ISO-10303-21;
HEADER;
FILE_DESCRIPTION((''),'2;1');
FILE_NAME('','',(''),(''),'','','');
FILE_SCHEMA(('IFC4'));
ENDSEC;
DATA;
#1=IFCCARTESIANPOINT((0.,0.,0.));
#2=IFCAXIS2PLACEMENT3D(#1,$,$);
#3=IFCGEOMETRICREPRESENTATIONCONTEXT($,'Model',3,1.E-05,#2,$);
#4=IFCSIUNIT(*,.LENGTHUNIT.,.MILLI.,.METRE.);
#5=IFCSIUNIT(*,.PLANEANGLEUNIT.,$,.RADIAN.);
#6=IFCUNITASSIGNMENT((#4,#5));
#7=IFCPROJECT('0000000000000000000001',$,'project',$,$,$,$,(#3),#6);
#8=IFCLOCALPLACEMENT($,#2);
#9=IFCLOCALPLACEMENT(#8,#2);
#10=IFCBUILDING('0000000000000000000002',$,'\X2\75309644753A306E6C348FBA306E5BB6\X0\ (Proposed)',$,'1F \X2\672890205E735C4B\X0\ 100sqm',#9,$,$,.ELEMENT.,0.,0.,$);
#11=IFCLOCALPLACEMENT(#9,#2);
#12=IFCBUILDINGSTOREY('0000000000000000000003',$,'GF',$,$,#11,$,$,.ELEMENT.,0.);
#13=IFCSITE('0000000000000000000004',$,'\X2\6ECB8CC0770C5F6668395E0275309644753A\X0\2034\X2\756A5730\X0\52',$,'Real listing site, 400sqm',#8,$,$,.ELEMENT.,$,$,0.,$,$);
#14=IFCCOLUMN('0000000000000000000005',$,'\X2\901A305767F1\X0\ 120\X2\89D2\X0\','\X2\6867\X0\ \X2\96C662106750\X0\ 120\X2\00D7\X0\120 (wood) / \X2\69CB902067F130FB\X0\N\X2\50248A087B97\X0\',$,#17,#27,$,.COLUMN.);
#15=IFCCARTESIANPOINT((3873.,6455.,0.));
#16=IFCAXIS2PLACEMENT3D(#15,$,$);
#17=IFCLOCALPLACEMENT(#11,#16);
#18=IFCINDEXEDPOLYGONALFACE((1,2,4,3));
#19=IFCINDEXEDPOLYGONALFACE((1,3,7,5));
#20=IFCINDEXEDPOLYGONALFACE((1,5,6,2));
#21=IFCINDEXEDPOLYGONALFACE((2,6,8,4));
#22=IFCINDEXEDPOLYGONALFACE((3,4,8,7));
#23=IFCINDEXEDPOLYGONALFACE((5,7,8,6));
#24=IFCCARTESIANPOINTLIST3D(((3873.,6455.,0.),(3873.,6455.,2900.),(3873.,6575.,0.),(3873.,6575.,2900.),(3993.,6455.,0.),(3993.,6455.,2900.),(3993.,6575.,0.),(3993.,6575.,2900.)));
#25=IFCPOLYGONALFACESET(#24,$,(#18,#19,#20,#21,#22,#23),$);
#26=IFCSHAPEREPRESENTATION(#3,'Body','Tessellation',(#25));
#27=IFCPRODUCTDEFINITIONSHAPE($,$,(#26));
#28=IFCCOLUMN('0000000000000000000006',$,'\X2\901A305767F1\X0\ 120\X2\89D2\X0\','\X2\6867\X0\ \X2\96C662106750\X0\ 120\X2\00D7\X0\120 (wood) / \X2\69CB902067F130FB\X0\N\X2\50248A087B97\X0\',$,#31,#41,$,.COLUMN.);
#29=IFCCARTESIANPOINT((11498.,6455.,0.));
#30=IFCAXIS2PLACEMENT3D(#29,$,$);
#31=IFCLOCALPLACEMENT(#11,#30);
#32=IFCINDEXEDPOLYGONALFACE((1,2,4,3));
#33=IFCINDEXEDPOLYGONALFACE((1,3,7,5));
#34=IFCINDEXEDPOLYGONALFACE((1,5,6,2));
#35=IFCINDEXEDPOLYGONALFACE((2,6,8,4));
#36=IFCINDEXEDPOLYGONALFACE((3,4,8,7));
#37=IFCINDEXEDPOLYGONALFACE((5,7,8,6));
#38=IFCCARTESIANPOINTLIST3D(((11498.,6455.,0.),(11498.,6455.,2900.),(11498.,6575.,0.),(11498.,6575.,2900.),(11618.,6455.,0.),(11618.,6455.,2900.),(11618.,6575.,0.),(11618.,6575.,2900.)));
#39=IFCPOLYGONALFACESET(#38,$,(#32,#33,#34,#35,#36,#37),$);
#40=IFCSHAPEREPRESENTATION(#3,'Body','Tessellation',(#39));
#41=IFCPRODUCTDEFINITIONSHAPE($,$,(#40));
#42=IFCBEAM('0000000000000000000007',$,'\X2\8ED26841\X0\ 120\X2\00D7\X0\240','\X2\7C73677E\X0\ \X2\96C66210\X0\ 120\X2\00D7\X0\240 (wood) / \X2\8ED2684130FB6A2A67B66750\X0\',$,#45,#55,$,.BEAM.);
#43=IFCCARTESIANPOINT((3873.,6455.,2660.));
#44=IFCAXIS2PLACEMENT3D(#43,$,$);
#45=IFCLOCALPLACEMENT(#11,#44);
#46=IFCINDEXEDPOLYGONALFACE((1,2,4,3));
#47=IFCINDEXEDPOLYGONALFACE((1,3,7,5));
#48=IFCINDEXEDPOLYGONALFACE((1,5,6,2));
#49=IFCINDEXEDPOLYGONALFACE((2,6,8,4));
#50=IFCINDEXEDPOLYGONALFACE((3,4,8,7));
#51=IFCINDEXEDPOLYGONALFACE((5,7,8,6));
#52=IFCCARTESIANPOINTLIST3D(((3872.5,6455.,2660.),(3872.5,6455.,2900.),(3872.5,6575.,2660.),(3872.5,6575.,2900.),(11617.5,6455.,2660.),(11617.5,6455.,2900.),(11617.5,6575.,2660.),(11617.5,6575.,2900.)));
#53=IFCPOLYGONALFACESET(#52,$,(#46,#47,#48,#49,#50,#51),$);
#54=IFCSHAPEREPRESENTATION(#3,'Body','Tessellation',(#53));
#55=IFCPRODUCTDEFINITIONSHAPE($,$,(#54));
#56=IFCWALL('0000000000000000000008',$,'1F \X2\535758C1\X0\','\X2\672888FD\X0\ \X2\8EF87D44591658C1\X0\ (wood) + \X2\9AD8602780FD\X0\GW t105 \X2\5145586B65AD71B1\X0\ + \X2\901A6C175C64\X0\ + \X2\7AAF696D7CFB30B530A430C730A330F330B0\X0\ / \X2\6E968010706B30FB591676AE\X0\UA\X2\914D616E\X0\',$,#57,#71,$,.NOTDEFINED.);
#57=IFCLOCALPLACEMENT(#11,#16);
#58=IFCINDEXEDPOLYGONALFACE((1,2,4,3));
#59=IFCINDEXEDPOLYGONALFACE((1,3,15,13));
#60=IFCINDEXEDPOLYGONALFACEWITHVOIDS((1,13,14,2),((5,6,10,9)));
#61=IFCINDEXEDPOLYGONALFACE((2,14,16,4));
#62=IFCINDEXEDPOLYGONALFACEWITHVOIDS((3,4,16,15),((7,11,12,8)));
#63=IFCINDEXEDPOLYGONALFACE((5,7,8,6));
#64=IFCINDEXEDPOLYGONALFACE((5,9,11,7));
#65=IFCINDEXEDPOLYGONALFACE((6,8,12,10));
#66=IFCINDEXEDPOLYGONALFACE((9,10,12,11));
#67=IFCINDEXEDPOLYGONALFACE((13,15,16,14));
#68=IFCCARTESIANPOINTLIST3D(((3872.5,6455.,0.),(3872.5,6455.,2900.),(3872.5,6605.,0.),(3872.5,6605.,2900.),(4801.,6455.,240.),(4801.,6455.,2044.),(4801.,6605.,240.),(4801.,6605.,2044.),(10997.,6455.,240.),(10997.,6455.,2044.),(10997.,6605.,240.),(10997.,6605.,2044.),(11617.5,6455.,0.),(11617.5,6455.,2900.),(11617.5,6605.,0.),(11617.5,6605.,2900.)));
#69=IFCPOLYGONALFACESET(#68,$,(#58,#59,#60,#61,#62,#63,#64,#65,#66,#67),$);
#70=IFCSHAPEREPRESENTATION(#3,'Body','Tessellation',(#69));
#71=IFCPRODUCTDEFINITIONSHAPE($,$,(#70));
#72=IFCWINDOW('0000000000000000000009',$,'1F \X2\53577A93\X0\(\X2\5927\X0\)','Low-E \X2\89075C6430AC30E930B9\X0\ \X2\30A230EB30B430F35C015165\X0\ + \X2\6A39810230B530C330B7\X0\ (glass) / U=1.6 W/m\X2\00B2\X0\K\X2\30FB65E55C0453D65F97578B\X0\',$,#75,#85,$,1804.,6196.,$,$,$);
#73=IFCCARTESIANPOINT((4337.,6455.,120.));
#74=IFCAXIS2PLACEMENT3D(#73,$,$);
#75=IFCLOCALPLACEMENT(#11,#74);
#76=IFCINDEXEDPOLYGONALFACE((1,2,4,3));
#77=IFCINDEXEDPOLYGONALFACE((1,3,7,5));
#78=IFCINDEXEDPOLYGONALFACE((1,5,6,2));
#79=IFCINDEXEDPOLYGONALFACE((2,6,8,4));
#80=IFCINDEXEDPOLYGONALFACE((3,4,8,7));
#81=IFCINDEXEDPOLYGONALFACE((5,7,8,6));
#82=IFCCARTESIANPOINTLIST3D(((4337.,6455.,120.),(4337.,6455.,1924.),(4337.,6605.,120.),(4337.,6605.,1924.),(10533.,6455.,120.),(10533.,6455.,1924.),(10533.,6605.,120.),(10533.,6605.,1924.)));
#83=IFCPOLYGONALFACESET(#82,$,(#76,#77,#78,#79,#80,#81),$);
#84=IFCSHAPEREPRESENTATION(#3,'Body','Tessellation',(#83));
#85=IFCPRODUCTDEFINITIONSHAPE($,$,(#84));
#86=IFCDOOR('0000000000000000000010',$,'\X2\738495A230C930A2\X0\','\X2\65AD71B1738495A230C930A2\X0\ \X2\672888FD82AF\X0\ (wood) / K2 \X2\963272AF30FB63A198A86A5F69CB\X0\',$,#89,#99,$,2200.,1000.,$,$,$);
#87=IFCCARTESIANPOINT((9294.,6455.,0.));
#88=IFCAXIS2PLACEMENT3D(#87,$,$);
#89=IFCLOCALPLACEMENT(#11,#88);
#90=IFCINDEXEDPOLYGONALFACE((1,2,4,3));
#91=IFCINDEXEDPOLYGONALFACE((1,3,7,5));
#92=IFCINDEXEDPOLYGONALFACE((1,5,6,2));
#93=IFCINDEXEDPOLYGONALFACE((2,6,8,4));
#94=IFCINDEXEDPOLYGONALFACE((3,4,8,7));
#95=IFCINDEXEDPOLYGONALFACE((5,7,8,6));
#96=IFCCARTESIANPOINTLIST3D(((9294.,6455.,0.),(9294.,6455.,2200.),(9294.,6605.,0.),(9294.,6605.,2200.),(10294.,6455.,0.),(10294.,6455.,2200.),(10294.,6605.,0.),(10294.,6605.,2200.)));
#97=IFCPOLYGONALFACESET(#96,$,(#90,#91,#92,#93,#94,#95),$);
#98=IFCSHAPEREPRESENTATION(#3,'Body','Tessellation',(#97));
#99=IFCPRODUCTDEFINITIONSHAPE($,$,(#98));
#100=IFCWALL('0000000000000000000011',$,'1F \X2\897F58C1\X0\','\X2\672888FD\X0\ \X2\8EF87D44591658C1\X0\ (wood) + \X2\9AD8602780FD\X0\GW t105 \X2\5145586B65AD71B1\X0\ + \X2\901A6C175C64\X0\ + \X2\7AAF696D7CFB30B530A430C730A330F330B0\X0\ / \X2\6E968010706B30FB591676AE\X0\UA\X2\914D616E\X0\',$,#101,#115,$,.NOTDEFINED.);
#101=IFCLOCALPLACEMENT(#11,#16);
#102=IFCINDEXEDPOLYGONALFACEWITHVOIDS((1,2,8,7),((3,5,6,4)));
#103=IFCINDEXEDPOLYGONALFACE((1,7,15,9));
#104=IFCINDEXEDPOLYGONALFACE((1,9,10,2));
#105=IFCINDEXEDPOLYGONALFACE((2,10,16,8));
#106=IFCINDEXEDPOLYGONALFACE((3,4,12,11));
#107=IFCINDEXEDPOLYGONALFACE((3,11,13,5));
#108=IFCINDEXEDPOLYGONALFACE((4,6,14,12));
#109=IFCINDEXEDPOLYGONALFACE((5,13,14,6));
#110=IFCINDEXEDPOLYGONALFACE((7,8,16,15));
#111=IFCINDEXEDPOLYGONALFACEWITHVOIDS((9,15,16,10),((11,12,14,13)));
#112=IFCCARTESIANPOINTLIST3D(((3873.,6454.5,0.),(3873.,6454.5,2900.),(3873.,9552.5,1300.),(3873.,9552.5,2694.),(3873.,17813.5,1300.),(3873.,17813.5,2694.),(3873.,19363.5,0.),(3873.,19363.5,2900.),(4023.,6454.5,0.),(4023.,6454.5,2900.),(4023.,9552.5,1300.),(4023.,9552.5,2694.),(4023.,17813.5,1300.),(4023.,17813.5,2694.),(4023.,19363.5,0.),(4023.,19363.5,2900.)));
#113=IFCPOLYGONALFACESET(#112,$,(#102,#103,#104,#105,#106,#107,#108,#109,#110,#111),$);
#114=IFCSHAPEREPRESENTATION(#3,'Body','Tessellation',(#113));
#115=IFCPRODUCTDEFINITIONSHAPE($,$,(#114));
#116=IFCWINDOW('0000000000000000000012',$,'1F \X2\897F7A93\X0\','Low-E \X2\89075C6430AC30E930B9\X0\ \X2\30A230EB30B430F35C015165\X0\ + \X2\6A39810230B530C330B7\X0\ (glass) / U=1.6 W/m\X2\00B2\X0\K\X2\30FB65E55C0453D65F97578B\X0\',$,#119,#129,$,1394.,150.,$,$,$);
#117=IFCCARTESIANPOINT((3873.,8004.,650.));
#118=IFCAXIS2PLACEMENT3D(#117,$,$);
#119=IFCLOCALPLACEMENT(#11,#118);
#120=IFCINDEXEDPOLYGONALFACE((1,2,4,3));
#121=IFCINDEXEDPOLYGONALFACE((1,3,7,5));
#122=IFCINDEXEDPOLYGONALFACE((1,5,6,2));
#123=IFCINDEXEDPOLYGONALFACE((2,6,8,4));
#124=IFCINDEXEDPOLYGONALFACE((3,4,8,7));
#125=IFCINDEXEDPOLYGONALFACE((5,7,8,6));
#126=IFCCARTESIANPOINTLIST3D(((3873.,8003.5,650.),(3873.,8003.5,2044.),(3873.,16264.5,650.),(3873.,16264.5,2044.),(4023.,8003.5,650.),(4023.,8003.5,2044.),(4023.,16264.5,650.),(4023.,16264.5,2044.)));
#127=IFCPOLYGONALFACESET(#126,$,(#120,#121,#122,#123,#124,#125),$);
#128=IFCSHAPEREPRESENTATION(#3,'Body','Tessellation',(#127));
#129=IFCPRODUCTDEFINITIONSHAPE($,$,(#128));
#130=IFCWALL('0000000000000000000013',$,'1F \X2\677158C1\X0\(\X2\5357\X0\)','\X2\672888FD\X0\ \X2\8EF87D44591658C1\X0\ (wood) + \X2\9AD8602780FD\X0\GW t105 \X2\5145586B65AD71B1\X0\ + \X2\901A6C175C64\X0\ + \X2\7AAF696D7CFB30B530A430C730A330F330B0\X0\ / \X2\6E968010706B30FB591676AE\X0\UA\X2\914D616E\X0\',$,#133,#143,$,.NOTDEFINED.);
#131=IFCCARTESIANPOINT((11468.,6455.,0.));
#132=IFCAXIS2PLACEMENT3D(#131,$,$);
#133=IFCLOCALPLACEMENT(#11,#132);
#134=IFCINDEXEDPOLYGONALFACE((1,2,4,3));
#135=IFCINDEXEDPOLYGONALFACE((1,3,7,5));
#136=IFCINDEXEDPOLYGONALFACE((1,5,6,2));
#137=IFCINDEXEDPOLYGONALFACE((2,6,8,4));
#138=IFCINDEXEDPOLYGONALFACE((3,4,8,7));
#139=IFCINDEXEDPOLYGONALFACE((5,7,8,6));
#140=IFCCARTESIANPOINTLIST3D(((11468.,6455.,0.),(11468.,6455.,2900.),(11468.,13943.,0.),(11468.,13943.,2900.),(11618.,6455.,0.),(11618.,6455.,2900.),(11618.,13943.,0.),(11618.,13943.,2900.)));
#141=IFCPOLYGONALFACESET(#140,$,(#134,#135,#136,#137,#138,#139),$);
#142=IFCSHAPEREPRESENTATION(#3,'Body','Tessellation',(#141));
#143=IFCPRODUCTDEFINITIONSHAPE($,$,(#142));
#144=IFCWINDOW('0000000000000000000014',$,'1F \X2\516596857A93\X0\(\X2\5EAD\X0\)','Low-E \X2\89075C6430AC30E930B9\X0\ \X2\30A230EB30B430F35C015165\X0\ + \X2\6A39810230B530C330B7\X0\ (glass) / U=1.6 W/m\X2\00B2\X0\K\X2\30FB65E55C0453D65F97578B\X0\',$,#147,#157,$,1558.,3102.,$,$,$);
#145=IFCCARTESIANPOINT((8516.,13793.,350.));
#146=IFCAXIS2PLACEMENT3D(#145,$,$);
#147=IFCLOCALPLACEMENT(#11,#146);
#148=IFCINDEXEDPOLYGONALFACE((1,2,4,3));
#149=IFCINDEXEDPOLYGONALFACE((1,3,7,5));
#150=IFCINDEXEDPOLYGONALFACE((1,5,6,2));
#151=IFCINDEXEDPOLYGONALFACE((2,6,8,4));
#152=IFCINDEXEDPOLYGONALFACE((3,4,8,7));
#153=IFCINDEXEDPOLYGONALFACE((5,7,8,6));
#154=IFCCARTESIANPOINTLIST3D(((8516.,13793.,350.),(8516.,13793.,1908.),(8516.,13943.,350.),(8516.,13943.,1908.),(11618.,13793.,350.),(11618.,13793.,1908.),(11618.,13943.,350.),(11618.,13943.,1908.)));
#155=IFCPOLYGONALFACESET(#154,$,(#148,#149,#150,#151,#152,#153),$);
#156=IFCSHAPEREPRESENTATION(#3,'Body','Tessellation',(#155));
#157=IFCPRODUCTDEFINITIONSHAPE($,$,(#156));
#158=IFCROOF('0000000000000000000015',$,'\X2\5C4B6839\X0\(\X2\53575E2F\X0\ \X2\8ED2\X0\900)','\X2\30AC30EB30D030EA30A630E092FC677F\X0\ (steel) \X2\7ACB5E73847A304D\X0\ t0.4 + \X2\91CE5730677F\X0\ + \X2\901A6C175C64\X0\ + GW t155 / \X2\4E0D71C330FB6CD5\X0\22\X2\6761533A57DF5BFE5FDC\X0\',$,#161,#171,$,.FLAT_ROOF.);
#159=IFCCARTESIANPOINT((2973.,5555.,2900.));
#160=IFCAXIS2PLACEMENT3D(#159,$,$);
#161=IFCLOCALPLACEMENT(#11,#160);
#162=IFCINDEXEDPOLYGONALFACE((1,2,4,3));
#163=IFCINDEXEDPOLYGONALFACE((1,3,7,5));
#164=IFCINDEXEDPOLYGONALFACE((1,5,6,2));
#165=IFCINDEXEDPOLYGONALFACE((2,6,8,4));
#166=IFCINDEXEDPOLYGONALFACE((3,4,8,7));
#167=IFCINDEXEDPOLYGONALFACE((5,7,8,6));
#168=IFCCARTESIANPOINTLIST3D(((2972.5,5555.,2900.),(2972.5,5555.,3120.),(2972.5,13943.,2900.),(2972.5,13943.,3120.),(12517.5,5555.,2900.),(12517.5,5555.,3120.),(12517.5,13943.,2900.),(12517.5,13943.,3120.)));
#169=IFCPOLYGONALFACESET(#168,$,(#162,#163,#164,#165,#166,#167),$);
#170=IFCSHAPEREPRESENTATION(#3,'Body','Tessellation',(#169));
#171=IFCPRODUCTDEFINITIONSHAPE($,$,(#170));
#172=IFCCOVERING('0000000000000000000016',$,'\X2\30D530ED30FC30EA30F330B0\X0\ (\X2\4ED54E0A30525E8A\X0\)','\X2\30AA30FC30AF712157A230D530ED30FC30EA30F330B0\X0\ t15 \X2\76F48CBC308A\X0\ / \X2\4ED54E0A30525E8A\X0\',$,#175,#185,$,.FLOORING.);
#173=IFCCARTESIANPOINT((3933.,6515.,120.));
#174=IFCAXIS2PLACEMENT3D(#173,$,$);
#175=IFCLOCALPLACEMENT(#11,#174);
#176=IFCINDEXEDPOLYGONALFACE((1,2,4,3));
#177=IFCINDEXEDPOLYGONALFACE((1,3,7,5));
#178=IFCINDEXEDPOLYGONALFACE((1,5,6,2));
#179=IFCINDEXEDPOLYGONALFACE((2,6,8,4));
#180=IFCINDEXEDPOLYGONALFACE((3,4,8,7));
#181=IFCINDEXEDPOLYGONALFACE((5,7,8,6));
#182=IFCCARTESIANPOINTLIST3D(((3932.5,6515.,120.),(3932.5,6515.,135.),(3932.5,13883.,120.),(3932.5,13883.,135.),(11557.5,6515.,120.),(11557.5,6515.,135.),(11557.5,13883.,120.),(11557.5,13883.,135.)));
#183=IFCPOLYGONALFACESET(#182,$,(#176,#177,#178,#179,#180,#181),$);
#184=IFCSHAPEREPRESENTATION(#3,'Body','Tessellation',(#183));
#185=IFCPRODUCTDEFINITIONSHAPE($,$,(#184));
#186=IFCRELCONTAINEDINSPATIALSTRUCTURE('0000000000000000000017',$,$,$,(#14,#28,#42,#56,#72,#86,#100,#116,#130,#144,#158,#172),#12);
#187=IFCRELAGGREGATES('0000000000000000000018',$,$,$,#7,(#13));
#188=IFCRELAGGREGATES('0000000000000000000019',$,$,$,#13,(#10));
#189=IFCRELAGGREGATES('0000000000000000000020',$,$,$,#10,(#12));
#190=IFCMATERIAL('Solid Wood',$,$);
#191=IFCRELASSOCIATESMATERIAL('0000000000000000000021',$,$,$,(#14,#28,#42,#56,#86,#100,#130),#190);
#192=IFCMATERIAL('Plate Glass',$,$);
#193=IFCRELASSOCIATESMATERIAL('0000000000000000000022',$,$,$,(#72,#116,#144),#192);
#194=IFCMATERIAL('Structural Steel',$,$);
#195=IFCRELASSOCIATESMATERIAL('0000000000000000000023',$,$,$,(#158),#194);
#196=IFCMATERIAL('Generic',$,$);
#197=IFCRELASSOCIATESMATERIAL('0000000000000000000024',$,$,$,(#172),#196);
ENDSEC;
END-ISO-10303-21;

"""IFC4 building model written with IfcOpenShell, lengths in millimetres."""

from ifc_helpers import new_model, si_unit, frame, frame_2d, origin, place, context, project, spatial, rectangle, extrude, material, element, fill, save


model = new_model("IFC4")

# Units and contexts
model_context = context("Model", 3, precision=1e-05, world=origin())
ifc_project = project(units=[si_unit("LENGTHUNIT", "METRE", prefix="MILLI"), si_unit("PLANEANGLEUNIT", "RADIAN")], contexts=[model_context])

# Site, building, storey
site_placement = place(None, origin())
site = spatial("IfcSite", under=ifc_project, at=site_placement, Name="滋賀県彦根市田附町2034番地52", ObjectType="Real listing site, 400sqm", CompositionType="ELEMENT", RefElevation=0.0)
building_placement = place(site_placement, origin())
building = spatial("IfcBuilding", under=site, at=building_placement, Name="田附町の水辺の家 (Proposed)", ObjectType="1F 木造平屋 100sqm", CompositionType="ELEMENT", ElevationOfRefHeight=0.0, ElevationOfTerrain=0.0)
storey_placement = place(building_placement, origin())
storey = spatial("IfcBuildingStorey", under=building, at=storey_placement, Name="GF", CompositionType="ELEMENT", Elevation=0.0)

# Columns
ifc_material_1 = material(Name="Solid Wood")
column_1_placement = place(storey_placement, frame((3873.0, 6455.0, 0.0)))
element("IfcColumn", 1, at=column_1_placement, inside=storey, material=ifc_material_1, Name="通し柱 120角", Description="桧 集成材 120×120 (wood) / 構造柱・N値計算", PredefinedType="COLUMN", context=model_context, shape_type="SweptSolid", body=[
    extrude(rectangle(XDim=120.0, YDim=120.0, at=frame_2d((60.0, 60.0))), frame((3873.0, 6455.0, 0.0)), (0.0, 0.0, 1.0), 2900.0),
])
column_2_placement = place(storey_placement, frame((11498.0, 6455.0, 0.0)))
element("IfcColumn", 2, at=column_2_placement, inside=storey, material=ifc_material_1, Name="通し柱 120角", Description="桧 集成材 120×120 (wood) / 構造柱・N値計算", PredefinedType="COLUMN", context=model_context, shape_type="SweptSolid", body=[
    extrude(rectangle(XDim=120.0, YDim=120.0, at=frame_2d((60.0, 60.0))), frame((11498.0, 6455.0, 0.0)), (0.0, 0.0, 1.0), 2900.0),
])

# Beam
beam_1_placement = place(storey_placement, frame((3873.0, 6455.0, 2660.0)))
element("IfcBeam", 3, at=beam_1_placement, inside=storey, material=ifc_material_1, Name="軒桁 120×240", Description="米松 集成 120×240 (wood) / 軒桁・横架材", PredefinedType="BEAM", context=model_context, shape_type="SweptSolid", body=[
    extrude(rectangle(XDim=7745.0, YDim=120.0, at=frame_2d((3872.0, 60.0))), frame((3873.0, 6455.0, 2660.0)), (0.0, 0.0, 1.0), 240.0),
])

# Wall, openings, window, door
wall_1_placement = place(storey_placement, frame((3873.0, 6455.0, 0.0)))
wall_1 = element("IfcWall", 4, at=wall_1_placement, inside=storey, material=ifc_material_1, Name="1F 南壁", Description="木製 軸組外壁 (wood) + 高性能GW t105 充填断熱 + 通気層 + 窯業系サイディング / 準耐火・外皮UA配慮", PredefinedType="NOTDEFINED", context=model_context, shape_type="SweptSolid", body=[
    extrude(rectangle(XDim=7745.0, YDim=150.0, at=frame_2d((3872.0, 75.0))), frame((3873.0, 6455.0, 0.0)), (0.0, 0.0, 1.0), 2900.0),
])
opening_1_placement = place(storey_placement, frame((4337.0, 6455.0, 120.0)))
opening_1 = element("IfcOpeningElement", 5, at=opening_1_placement, cuts=wall_1, PredefinedType="NOTDEFINED", context=model_context, shape_type="SweptSolid", body=[
    extrude(rectangle(XDim=6196.0, YDim=150.0, at=frame_2d((3098.0, 75.0))), frame((4337.0, 6455.0, 120.0)), (0.0, 0.0, 1.0), 1804.0),
])
opening_2_placement = place(storey_placement, frame((9294.0, 6455.0, 0.0)))
opening_2 = element("IfcOpeningElement", 6, at=opening_2_placement, cuts=wall_1, PredefinedType="NOTDEFINED", context=model_context, shape_type="SweptSolid", body=[
    extrude(rectangle(XDim=1000.0, YDim=150.0, at=frame_2d((500.0, 75.0))), frame((9294.0, 6455.0, 0.0)), (0.0, 0.0, 1.0), 2200.0),
])
ifc_material_2 = material(Name="Plate Glass")
window_1_placement = place(storey_placement, frame((4337.0, 6455.0, 120.0)))
window_1 = element("IfcWindow", 7, at=window_1_placement, inside=storey, material=ifc_material_2, Name="1F 南窓(大)", Description="Low-E 複層ガラス アルゴン封入 + 樹脂サッシ (glass) / U=1.6 W/m²K・日射取得型", OverallHeight=1804.0, OverallWidth=6196.0, context=model_context, shape_type="SweptSolid", body=[
    extrude(rectangle(XDim=6196.0, YDim=150.0, at=frame_2d((3098.0, 75.0))), frame((4337.0, 6455.0, 120.0)), (0.0, 0.0, 1.0), 1804.0),
])
fill(opening_1, window_1)
door_1_placement = place(storey_placement, frame((9294.0, 6455.0, 0.0)))
door_1 = element("IfcDoor", 8, at=door_1_placement, inside=storey, material=ifc_material_1, Name="玄関ドア", Description="断熱玄関ドア 木製芯 (wood) / K2 防犯・採風機構", OverallHeight=2200.0, OverallWidth=1000.0, context=model_context, shape_type="SweptSolid", body=[
    extrude(rectangle(XDim=1000.0, YDim=150.0, at=frame_2d((500.0, 75.0))), frame((9294.0, 6455.0, 0.0)), (0.0, 0.0, 1.0), 2200.0),
])
fill(opening_2, door_1)

# Walls, openings, windows
wall_2_placement = place(storey_placement, frame((3873.0, 6455.0, 0.0)))
wall_2 = element("IfcWall", 9, at=wall_2_placement, inside=storey, material=ifc_material_1, Name="1F 西壁", Description="木製 軸組外壁 (wood) + 高性能GW t105 充填断熱 + 通気層 + 窯業系サイディング / 準耐火・外皮UA配慮", PredefinedType="NOTDEFINED", context=model_context, shape_type="SweptSolid", body=[
    extrude(rectangle(XDim=150.0, YDim=12909.0, at=frame_2d((75.0, 6454.0))), frame((3873.0, 6455.0, 0.0)), (0.0, 0.0, 1.0), 2900.0),
])
opening_3_placement = place(storey_placement, frame((3873.0, 8004.0, 650.0)))
opening_3 = element("IfcOpeningElement", 10, at=opening_3_placement, cuts=wall_2, PredefinedType="NOTDEFINED", context=model_context, shape_type="SweptSolid", body=[
    extrude(rectangle(XDim=150.0, YDim=8261.0, at=frame_2d((75.0, 4130.0))), frame((3873.0, 8004.0, 650.0)), (0.0, 0.0, 1.0), 1394.0),
])
window_2_placement = place(storey_placement, frame((3873.0, 8004.0, 650.0)))
window_2 = element("IfcWindow", 11, at=window_2_placement, inside=storey, material=ifc_material_2, Name="1F 西窓", Description="Low-E 複層ガラス アルゴン封入 + 樹脂サッシ (glass) / U=1.6 W/m²K・日射取得型", OverallHeight=1394.0, OverallWidth=150.0, context=model_context, shape_type="SweptSolid", body=[
    extrude(rectangle(XDim=150.0, YDim=8261.0, at=frame_2d((75.0, 4130.0))), frame((3873.0, 8004.0, 650.0)), (0.0, 0.0, 1.0), 1394.0),
])
fill(opening_3, window_2)
wall_3_placement = place(storey_placement, frame((11468.0, 6455.0, 0.0)))
wall_3 = element("IfcWall", 12, at=wall_3_placement, inside=storey, material=ifc_material_1, Name="1F 東壁(南)", Description="木製 軸組外壁 (wood) + 高性能GW t105 充填断熱 + 通気層 + 窯業系サイディング / 準耐火・外皮UA配慮", PredefinedType="NOTDEFINED", context=model_context, shape_type="SweptSolid", body=[
    extrude(rectangle(XDim=150.0, YDim=7488.0, at=frame_2d((75.0, 3744.0))), frame((11468.0, 6455.0, 0.0)), (0.0, 0.0, 1.0), 2900.0),
])
opening_4_placement = place(storey_placement, frame((8516.0, 13793.0, 350.0)))
opening_4 = element("IfcOpeningElement", 13, at=opening_4_placement, cuts=wall_3, PredefinedType="NOTDEFINED", context=model_context, shape_type="SweptSolid", body=[
    extrude(rectangle(XDim=3102.0, YDim=150.0, at=frame_2d((1551.0, 75.0))), frame((8516.0, 13793.0, 350.0)), (0.0, 0.0, 1.0), 1558.0),
])
window_3_placement = place(storey_placement, frame((8516.0, 13793.0, 350.0)))
window_3 = element("IfcWindow", 14, at=window_3_placement, inside=storey, material=ifc_material_2, Name="1F 入隅窓(庭)", Description="Low-E 複層ガラス アルゴン封入 + 樹脂サッシ (glass) / U=1.6 W/m²K・日射取得型", OverallHeight=1558.0, OverallWidth=3102.0, context=model_context, shape_type="SweptSolid", body=[
    extrude(rectangle(XDim=3102.0, YDim=150.0, at=frame_2d((1551.0, 75.0))), frame((8516.0, 13793.0, 350.0)), (0.0, 0.0, 1.0), 1558.0),
])
fill(opening_4, window_3)

# Roof
ifc_material_3 = material(Name="Structural Steel")
roof_placement = place(storey_placement, frame((2973.0, 5555.0, 2900.0)))
element("IfcRoof", 15, at=roof_placement, inside=storey, material=ifc_material_3, Name="屋根(南帯 軒900)", Description="ガルバリウム鋼板 (steel) 立平葺き t0.4 + 野地板 + 通気層 + GW t155 / 不燃・法22条区域対応", PredefinedType="FLAT_ROOF", context=model_context, shape_type="SweptSolid", body=[
    extrude(rectangle(XDim=9545.0, YDim=8388.0, at=frame_2d((4772.0, 4194.0))), frame((2973.0, 5555.0, 2900.0)), (0.0, 0.0, 1.0), 220.0),
])

# Covering
ifc_material_4 = material(Name="Generic")
covering_1_placement = place(storey_placement, frame((3933.0, 6515.0, 120.0)))
element("IfcCovering", 16, at=covering_1_placement, inside=storey, material=ifc_material_4, Name="フローリング (仕上げ床)", Description="オーク無垢フローリング t15 直貼り / 仕上げ床", PredefinedType="FLOORING", context=model_context, shape_type="SweptSolid", body=[
    extrude(rectangle(XDim=7625.0, YDim=7368.0, at=frame_2d((3812.0, 3684.0))), frame((3933.0, 6515.0, 120.0)), (0.0, 0.0, 1.0), 15.0),
])

save(model, "model.ifc")
